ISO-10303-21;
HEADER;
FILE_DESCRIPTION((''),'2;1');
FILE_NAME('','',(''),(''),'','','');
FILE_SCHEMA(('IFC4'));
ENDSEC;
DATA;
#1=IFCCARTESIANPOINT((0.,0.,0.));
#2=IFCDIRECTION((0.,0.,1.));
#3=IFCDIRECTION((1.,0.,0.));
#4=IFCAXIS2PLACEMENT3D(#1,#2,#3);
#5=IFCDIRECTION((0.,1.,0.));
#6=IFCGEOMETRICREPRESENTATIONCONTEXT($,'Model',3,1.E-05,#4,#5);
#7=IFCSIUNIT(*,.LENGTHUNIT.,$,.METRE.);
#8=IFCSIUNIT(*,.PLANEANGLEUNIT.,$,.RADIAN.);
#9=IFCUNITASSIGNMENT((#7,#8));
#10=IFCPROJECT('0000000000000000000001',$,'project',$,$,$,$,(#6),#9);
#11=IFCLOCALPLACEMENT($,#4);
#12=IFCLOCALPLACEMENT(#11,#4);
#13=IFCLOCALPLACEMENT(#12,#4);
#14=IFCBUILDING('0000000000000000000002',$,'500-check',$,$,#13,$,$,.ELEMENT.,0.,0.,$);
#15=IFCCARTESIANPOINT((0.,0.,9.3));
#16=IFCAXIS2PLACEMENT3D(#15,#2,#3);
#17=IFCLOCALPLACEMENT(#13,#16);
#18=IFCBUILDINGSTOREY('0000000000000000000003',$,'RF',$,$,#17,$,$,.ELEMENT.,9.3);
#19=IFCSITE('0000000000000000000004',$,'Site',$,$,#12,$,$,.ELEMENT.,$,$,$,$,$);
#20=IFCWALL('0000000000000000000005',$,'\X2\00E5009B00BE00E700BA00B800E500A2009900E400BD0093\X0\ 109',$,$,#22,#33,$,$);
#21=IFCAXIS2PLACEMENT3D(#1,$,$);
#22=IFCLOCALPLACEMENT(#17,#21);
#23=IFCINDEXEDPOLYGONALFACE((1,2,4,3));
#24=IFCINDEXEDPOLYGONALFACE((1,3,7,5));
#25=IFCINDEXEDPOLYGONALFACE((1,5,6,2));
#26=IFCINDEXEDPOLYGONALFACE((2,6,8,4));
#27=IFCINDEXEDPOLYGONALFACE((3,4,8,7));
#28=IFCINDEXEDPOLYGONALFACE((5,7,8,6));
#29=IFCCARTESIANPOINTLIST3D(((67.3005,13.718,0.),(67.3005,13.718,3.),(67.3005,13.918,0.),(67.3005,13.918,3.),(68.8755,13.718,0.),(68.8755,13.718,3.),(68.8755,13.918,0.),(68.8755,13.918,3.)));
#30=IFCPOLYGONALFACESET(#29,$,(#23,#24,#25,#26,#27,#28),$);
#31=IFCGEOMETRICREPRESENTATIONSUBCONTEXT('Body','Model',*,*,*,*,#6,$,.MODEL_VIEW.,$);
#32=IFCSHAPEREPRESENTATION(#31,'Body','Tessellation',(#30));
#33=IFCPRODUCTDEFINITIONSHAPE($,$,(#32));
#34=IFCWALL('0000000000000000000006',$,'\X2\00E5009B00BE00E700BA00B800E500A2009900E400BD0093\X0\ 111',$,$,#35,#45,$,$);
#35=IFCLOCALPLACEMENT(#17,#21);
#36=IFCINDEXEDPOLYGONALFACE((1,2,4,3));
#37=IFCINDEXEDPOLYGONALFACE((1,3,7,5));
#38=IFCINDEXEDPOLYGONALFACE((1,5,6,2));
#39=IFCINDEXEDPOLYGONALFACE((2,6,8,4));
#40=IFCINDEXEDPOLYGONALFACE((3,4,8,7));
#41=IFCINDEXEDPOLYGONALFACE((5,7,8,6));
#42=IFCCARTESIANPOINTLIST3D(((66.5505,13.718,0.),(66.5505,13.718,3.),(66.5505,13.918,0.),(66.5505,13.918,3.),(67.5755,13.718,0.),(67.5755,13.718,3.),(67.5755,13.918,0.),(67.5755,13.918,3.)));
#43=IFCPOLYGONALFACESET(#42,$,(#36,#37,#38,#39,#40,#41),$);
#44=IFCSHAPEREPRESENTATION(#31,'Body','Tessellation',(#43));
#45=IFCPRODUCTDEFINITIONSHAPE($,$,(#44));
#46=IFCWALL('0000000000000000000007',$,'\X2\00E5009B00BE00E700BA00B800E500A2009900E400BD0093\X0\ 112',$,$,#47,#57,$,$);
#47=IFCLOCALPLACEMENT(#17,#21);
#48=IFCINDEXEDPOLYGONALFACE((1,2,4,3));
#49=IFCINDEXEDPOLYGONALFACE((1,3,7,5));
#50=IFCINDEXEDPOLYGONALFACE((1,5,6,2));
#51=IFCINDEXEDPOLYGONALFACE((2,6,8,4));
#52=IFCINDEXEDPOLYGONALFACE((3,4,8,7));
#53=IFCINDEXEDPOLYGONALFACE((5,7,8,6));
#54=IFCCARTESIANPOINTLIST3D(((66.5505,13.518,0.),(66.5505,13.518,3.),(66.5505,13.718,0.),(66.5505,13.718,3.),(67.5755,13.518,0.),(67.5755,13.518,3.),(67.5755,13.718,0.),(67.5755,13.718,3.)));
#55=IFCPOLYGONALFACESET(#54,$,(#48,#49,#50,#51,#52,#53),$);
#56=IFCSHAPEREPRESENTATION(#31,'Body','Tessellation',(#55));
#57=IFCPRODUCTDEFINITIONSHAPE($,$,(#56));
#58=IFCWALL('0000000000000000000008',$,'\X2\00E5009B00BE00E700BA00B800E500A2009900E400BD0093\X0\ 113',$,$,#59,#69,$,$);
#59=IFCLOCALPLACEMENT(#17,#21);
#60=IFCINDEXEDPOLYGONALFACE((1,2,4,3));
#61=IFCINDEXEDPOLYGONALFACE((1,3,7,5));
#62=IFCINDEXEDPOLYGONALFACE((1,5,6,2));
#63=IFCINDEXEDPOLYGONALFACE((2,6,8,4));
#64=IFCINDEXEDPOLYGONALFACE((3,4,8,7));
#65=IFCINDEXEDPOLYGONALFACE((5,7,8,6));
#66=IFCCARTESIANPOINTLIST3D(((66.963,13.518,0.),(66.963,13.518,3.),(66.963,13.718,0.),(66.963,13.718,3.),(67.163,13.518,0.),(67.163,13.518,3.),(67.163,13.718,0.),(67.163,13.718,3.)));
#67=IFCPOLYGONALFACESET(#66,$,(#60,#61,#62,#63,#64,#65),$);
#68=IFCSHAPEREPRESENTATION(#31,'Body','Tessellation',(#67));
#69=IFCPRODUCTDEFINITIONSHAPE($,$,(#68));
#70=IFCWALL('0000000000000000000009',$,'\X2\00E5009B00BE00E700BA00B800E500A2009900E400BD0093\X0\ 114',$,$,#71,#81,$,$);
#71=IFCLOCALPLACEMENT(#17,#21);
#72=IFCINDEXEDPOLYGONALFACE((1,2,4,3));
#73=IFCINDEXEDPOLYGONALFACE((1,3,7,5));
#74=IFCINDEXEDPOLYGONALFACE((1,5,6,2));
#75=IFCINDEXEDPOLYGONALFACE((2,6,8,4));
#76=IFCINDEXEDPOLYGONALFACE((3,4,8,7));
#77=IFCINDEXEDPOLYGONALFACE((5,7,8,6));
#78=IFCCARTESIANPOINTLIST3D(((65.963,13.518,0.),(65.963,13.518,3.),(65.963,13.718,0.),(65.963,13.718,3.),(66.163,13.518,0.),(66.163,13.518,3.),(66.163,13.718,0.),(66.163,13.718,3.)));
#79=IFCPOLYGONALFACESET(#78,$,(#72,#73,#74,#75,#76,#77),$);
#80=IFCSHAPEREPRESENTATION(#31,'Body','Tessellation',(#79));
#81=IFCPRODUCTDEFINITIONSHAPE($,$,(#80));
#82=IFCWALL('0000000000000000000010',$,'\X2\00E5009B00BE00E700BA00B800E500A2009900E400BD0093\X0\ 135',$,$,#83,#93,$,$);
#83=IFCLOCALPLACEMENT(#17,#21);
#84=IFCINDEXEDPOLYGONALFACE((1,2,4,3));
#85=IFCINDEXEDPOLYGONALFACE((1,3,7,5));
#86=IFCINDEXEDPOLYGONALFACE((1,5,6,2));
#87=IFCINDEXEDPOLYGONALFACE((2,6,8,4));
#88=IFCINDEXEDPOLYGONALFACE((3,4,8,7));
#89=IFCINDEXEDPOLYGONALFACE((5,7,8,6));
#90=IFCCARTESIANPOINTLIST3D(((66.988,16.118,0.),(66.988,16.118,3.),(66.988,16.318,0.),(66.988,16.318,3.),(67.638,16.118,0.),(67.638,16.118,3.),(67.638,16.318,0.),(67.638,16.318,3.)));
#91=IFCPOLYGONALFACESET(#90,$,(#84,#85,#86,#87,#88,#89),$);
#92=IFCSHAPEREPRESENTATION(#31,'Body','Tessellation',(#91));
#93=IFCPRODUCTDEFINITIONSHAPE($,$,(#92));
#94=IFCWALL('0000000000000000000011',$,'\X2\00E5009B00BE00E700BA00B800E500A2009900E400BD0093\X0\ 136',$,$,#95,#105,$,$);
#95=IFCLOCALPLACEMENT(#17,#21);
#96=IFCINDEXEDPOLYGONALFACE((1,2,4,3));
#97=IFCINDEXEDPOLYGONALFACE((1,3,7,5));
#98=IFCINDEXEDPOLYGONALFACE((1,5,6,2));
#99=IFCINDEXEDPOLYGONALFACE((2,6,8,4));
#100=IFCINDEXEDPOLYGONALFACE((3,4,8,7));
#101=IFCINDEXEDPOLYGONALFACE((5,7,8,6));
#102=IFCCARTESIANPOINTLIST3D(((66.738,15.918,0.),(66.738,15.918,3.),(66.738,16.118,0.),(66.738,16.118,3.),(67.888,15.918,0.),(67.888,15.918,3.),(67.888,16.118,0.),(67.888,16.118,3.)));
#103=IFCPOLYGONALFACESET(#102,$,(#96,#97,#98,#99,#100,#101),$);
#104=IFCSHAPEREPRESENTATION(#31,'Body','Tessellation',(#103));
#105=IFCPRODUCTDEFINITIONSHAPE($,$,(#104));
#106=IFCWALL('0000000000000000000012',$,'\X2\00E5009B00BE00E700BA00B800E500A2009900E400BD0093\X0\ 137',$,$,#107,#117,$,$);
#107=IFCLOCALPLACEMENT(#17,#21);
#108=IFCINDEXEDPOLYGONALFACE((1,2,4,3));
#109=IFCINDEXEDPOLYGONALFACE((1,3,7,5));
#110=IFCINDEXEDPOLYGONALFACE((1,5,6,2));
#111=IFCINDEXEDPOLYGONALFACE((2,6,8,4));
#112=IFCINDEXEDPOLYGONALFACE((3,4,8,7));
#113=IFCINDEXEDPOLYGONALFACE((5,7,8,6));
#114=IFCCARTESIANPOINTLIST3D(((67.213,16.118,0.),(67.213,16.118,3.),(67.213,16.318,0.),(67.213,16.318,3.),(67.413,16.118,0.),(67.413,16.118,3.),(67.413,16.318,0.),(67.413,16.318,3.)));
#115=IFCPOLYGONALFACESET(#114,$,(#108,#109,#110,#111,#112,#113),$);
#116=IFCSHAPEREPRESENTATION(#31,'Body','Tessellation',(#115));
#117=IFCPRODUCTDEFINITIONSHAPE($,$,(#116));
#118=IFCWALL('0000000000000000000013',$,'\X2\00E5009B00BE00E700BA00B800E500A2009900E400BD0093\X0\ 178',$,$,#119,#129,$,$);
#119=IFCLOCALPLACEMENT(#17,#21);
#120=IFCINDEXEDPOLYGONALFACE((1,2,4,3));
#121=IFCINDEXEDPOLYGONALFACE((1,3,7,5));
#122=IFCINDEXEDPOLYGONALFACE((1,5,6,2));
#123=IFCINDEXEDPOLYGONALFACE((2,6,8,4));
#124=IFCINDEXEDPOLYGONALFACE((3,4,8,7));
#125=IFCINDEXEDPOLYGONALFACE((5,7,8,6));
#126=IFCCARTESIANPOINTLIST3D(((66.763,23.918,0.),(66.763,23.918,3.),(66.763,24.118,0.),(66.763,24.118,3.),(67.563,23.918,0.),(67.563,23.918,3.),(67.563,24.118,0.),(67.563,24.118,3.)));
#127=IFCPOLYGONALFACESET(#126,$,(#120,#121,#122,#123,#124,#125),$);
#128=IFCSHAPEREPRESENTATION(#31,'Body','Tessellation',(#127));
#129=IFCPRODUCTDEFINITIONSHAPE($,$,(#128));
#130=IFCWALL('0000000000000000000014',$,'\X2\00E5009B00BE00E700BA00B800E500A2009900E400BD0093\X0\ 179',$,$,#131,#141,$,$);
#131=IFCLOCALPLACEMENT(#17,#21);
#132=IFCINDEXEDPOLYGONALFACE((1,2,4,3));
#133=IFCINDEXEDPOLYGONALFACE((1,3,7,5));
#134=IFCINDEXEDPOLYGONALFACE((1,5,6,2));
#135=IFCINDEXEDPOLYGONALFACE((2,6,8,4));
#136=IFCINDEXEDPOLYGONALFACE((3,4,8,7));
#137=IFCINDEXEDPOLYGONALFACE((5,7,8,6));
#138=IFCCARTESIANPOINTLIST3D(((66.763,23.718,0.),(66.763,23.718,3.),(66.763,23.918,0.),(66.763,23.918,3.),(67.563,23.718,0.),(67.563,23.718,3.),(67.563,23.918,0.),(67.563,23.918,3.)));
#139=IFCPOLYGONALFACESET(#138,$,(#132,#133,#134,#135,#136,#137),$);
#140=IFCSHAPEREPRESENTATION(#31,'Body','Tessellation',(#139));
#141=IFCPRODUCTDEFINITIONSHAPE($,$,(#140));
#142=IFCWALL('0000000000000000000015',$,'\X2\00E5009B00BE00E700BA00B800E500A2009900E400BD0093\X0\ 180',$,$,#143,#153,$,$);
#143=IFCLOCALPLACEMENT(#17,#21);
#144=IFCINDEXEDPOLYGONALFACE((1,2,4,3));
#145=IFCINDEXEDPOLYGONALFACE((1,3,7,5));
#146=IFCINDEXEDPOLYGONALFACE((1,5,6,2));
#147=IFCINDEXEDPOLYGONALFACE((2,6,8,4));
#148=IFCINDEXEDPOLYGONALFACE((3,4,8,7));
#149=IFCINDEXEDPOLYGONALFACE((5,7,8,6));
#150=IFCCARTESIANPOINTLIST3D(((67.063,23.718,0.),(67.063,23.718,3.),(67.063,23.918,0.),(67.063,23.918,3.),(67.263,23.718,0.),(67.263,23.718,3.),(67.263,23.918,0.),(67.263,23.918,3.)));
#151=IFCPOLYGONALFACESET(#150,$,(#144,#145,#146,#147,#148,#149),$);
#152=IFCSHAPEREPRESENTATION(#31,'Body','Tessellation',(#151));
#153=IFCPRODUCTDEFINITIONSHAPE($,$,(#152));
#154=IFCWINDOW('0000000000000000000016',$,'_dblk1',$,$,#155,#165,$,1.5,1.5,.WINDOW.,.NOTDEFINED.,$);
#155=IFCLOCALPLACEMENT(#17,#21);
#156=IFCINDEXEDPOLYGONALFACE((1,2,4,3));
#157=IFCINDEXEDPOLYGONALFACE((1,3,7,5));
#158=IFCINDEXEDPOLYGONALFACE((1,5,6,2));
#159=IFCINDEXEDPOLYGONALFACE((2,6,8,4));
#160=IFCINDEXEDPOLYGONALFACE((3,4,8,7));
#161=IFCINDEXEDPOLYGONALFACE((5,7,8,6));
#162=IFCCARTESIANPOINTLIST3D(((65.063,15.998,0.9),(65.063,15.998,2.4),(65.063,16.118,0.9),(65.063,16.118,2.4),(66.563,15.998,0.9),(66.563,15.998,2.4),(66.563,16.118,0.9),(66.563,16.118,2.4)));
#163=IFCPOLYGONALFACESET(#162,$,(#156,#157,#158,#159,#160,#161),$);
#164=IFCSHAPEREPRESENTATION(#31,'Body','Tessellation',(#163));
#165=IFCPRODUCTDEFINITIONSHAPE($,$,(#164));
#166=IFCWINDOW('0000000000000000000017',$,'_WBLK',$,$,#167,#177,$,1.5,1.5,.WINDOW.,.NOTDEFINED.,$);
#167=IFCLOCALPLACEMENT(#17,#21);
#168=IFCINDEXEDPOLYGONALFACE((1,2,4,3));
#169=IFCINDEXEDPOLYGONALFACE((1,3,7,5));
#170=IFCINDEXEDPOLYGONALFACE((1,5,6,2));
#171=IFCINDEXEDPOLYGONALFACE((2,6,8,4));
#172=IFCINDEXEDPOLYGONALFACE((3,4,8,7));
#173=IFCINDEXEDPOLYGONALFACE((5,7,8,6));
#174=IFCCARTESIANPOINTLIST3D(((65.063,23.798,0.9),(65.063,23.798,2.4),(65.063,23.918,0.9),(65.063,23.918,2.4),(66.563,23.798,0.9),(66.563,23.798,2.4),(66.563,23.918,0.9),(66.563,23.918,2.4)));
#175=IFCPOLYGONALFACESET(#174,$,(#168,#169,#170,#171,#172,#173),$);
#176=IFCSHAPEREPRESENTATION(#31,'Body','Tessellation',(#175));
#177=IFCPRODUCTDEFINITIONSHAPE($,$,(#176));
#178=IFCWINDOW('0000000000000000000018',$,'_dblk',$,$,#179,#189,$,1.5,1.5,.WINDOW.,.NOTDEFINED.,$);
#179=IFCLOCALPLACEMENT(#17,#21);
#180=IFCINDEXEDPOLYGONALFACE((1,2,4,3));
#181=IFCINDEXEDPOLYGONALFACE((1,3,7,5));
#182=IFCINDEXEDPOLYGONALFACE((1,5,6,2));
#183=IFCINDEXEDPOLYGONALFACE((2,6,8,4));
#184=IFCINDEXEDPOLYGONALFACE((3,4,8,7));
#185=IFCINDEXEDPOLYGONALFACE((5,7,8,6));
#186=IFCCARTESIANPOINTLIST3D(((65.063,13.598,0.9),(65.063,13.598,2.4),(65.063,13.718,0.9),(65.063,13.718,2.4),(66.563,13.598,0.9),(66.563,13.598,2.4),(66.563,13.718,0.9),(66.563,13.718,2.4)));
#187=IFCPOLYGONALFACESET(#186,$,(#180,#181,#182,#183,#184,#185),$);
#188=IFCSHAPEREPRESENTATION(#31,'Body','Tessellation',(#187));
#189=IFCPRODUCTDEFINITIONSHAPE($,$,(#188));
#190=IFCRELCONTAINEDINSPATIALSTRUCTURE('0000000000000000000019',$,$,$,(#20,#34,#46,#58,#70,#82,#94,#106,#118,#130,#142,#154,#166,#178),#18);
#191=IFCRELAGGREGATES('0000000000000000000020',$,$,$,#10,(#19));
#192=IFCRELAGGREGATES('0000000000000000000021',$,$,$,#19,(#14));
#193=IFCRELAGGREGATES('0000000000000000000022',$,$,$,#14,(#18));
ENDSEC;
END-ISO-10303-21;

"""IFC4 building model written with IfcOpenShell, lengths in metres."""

from ifc_helpers import new_model, si_unit, direction, frame, frame_2d, origin_with_axes, place, context, subcontext, project, spatial, rectangle, extrude, element, save


model = new_model("IFC4")

# Units and contexts
model_context = context("Model", 3, precision=1e-05, world=origin_with_axes(), true_north=direction((0.0, 1.0, 0.0)))
body_context = subcontext(model_context, "Body", "Model", "MODEL_VIEW")
ifc_project = project(units=[si_unit("LENGTHUNIT", "METRE"), si_unit("PLANEANGLEUNIT", "RADIAN")], contexts=[model_context])

# Site, building, storey
placement = place(None, origin_with_axes())
site_placement = place(placement, origin_with_axes())
site = spatial("IfcSite", under=ifc_project, at=site_placement, Name="Site", CompositionType="ELEMENT")
building_placement = place(site_placement, origin_with_axes())
building = spatial("IfcBuilding", under=site, at=building_placement, Name="500-check", CompositionType="ELEMENT", ElevationOfRefHeight=0.0, ElevationOfTerrain=0.0)
storey_placement = place(building_placement, frame((0.0, 0.0, 9.3), z_axis=(0.0, 0.0, 1.0), x_axis=(1.0, 0.0, 0.0)))
storey = spatial("IfcBuildingStorey", under=building, at=storey_placement, Name="RF", CompositionType="ELEMENT", Elevation=9.3)

# Walls
wall_1_placement = place(storey_placement, frame((68.088, 13.818, 0.0), z_axis=(0.0, 0.0, 1.0), x_axis=(1.0, 0.0, 0.0)))
element("IfcWall", 1, at=wall_1_placement, inside=storey, Name="å\u009b¾çº¸å¢\u0099ä½\u0093 109", context=body_context, shape_type="SweptSolid", body=[
    extrude(rectangle(XDim=1.575, YDim=0.2, at=frame_2d((0.0, 0.0), x_axis=(1.0, 0.0, 0.0))), frame((0.0, 0.0, 0.0), z_axis=(0.0, 0.0, 1.0)), (0.0, 0.0, 1.0), 3.0),
])
for number, where, z_axis, x_axis, name in (
    (2, (67.063, 13.818, 0.0), (0.0, 0.0, 1.0), (1.0, 0.0, 0.0), "å\u009b¾çº¸å¢\u0099ä½\u0093 111"),
    (3, (67.063, 13.618, 0.0), (0.0, 0.0, 1.0), (1.0, 0.0, 0.0), "å\u009b¾çº¸å¢\u0099ä½\u0093 112"),
):
    element("IfcWall", number, at=place(storey_placement, frame(where, z_axis=z_axis, x_axis=x_axis)), inside=storey, Name=name, context=body_context, shape_type="SweptSolid", body=[
        extrude(rectangle(XDim=1.025, YDim=0.2, at=frame_2d((0.0, 0.0), x_axis=(1.0, 0.0, 0.0))), frame((0.0, 0.0, 0.0), z_axis=(0.0, 0.0, 1.0)), (0.0, 0.0, 1.0), 3.0),
    ])
for number, where, z_axis, x_axis, name in (
    (4, (67.063, 13.618, 0.0), (0.0, 0.0, 1.0), (0.0, 1.0, 0.0), "å\u009b¾çº¸å¢\u0099ä½\u0093 113"),
    (5, (66.063, 13.618, 0.0), (0.0, 0.0, 1.0), (0.0, 1.0, 0.0), "å\u009b¾çº¸å¢\u0099ä½\u0093 114"),
):
    element("IfcWall", number, at=place(storey_placement, frame(where, z_axis=z_axis, x_axis=x_axis)), inside=storey, Name=name, context=body_context, shape_type="SweptSolid", body=[
        extrude(rectangle(XDim=0.2, YDim=0.2, at=frame_2d((0.0, 0.0), x_axis=(1.0, 0.0, 0.0))), frame((0.0, 0.0, 0.0), z_axis=(0.0, 0.0, 1.0)), (0.0, 0.0, 1.0), 3.0),
    ])
wall_2_placement = place(storey_placement, frame((67.313, 16.218, 0.0), z_axis=(0.0, 0.0, 1.0), x_axis=(1.0, 0.0, 0.0)))
element("IfcWall", 6, at=wall_2_placement, inside=storey, Name="å\u009b¾çº¸å¢\u0099ä½\u0093 135", context=body_context, shape_type="SweptSolid", body=[
    extrude(rectangle(XDim=0.65, YDim=0.2, at=frame_2d((0.0, 0.0), x_axis=(1.0, 0.0, 0.0))), frame((0.0, 0.0, 0.0), z_axis=(0.0, 0.0, 1.0)), (0.0, 0.0, 1.0), 3.0),
])
wall_3_placement = place(storey_placement, frame((67.313, 16.018, 0.0), z_axis=(0.0, 0.0, 1.0), x_axis=(1.0, 0.0, 0.0)))
element("IfcWall", 7, at=wall_3_placement, inside=storey, Name="å\u009b¾çº¸å¢\u0099ä½\u0093 136", context=body_context, shape_type="SweptSolid", body=[
    extrude(rectangle(XDim=1.15, YDim=0.2, at=frame_2d((0.0, 0.0), x_axis=(1.0, 0.0, 0.0))), frame((0.0, 0.0, 0.0), z_axis=(0.0, 0.0, 1.0)), (0.0, 0.0, 1.0), 3.0),
])
wall_4_placement = place(storey_placement, frame((67.313, 16.218, 0.0), z_axis=(0.0, 0.0, 1.0), x_axis=(0.0, -1.0, 0.0)))
element("IfcWall", 8, at=wall_4_placement, inside=storey, Name="å\u009b¾çº¸å¢\u0099ä½\u0093 137", context=body_context, shape_type="SweptSolid", body=[
    extrude(rectangle(XDim=0.2, YDim=0.2, at=frame_2d((0.0, 0.0), x_axis=(1.0, 0.0, 0.0))), frame((0.0, 0.0, 0.0), z_axis=(0.0, 0.0, 1.0)), (0.0, 0.0, 1.0), 3.0),
])
for number, where, z_axis, x_axis, name in (
    (9, (67.163, 24.018, 0.0), (0.0, 0.0, 1.0), (1.0, 0.0, 0.0), "å\u009b¾çº¸å¢\u0099ä½\u0093 178"),
    (10, (67.163, 23.818, 0.0), (0.0, 0.0, 1.0), (1.0, 0.0, 0.0), "å\u009b¾çº¸å¢\u0099ä½\u0093 179"),
):
    element("IfcWall", number, at=place(storey_placement, frame(where, z_axis=z_axis, x_axis=x_axis)), inside=storey, Name=name, context=body_context, shape_type="SweptSolid", body=[
        extrude(rectangle(XDim=0.8, YDim=0.2, at=frame_2d((0.0, 0.0), x_axis=(1.0, 0.0, 0.0))), frame((0.0, 0.0, 0.0), z_axis=(0.0, 0.0, 1.0)), (0.0, 0.0, 1.0), 3.0),
    ])
wall_5_placement = place(storey_placement, frame((67.163, 23.818, 0.0), z_axis=(0.0, 0.0, 1.0), x_axis=(0.0, 1.0, 0.0)))
element("IfcWall", 11, at=wall_5_placement, inside=storey, Name="å\u009b¾çº¸å¢\u0099ä½\u0093 180", context=body_context, shape_type="SweptSolid", body=[
    extrude(rectangle(XDim=0.2, YDim=0.2, at=frame_2d((0.0, 0.0), x_axis=(1.0, 0.0, 0.0))), frame((0.0, 0.0, 0.0), z_axis=(0.0, 0.0, 1.0)), (0.0, 0.0, 1.0), 3.0),
])

# Windows
for number, where, z_axis, x_axis, name in (
    (12, (65.813, 16.058, 0.9), (0.0, 0.0, 1.0), (1.0, 0.0, 0.0), "_dblk1"),
    (13, (65.813, 23.858, 0.9), (0.0, 0.0, 1.0), (1.0, 0.0, 0.0), "_WBLK"),
    (14, (65.813, 13.658, 0.9), (0.0, 0.0, 1.0), (1.0, 0.0, 0.0), "_dblk"),
):
    element("IfcWindow", number, at=place(storey_placement, frame(where, z_axis=z_axis, x_axis=x_axis)), inside=storey, Name=name, OverallHeight=1.5, OverallWidth=1.5, PartitioningType="NOTDEFINED", PredefinedType="WINDOW", context=body_context, shape_type="SweptSolid", body=[
        extrude(rectangle(XDim=1.5, YDim=0.12, at=frame_2d((0.0, 0.0), x_axis=(1.0, 0.0, 0.0))), frame((0.0, 0.0, 0.0), z_axis=(0.0, 0.0, 1.0)), (0.0, 0.0, 1.0), 1.5),
    ])

save(model, "model.ifc")
